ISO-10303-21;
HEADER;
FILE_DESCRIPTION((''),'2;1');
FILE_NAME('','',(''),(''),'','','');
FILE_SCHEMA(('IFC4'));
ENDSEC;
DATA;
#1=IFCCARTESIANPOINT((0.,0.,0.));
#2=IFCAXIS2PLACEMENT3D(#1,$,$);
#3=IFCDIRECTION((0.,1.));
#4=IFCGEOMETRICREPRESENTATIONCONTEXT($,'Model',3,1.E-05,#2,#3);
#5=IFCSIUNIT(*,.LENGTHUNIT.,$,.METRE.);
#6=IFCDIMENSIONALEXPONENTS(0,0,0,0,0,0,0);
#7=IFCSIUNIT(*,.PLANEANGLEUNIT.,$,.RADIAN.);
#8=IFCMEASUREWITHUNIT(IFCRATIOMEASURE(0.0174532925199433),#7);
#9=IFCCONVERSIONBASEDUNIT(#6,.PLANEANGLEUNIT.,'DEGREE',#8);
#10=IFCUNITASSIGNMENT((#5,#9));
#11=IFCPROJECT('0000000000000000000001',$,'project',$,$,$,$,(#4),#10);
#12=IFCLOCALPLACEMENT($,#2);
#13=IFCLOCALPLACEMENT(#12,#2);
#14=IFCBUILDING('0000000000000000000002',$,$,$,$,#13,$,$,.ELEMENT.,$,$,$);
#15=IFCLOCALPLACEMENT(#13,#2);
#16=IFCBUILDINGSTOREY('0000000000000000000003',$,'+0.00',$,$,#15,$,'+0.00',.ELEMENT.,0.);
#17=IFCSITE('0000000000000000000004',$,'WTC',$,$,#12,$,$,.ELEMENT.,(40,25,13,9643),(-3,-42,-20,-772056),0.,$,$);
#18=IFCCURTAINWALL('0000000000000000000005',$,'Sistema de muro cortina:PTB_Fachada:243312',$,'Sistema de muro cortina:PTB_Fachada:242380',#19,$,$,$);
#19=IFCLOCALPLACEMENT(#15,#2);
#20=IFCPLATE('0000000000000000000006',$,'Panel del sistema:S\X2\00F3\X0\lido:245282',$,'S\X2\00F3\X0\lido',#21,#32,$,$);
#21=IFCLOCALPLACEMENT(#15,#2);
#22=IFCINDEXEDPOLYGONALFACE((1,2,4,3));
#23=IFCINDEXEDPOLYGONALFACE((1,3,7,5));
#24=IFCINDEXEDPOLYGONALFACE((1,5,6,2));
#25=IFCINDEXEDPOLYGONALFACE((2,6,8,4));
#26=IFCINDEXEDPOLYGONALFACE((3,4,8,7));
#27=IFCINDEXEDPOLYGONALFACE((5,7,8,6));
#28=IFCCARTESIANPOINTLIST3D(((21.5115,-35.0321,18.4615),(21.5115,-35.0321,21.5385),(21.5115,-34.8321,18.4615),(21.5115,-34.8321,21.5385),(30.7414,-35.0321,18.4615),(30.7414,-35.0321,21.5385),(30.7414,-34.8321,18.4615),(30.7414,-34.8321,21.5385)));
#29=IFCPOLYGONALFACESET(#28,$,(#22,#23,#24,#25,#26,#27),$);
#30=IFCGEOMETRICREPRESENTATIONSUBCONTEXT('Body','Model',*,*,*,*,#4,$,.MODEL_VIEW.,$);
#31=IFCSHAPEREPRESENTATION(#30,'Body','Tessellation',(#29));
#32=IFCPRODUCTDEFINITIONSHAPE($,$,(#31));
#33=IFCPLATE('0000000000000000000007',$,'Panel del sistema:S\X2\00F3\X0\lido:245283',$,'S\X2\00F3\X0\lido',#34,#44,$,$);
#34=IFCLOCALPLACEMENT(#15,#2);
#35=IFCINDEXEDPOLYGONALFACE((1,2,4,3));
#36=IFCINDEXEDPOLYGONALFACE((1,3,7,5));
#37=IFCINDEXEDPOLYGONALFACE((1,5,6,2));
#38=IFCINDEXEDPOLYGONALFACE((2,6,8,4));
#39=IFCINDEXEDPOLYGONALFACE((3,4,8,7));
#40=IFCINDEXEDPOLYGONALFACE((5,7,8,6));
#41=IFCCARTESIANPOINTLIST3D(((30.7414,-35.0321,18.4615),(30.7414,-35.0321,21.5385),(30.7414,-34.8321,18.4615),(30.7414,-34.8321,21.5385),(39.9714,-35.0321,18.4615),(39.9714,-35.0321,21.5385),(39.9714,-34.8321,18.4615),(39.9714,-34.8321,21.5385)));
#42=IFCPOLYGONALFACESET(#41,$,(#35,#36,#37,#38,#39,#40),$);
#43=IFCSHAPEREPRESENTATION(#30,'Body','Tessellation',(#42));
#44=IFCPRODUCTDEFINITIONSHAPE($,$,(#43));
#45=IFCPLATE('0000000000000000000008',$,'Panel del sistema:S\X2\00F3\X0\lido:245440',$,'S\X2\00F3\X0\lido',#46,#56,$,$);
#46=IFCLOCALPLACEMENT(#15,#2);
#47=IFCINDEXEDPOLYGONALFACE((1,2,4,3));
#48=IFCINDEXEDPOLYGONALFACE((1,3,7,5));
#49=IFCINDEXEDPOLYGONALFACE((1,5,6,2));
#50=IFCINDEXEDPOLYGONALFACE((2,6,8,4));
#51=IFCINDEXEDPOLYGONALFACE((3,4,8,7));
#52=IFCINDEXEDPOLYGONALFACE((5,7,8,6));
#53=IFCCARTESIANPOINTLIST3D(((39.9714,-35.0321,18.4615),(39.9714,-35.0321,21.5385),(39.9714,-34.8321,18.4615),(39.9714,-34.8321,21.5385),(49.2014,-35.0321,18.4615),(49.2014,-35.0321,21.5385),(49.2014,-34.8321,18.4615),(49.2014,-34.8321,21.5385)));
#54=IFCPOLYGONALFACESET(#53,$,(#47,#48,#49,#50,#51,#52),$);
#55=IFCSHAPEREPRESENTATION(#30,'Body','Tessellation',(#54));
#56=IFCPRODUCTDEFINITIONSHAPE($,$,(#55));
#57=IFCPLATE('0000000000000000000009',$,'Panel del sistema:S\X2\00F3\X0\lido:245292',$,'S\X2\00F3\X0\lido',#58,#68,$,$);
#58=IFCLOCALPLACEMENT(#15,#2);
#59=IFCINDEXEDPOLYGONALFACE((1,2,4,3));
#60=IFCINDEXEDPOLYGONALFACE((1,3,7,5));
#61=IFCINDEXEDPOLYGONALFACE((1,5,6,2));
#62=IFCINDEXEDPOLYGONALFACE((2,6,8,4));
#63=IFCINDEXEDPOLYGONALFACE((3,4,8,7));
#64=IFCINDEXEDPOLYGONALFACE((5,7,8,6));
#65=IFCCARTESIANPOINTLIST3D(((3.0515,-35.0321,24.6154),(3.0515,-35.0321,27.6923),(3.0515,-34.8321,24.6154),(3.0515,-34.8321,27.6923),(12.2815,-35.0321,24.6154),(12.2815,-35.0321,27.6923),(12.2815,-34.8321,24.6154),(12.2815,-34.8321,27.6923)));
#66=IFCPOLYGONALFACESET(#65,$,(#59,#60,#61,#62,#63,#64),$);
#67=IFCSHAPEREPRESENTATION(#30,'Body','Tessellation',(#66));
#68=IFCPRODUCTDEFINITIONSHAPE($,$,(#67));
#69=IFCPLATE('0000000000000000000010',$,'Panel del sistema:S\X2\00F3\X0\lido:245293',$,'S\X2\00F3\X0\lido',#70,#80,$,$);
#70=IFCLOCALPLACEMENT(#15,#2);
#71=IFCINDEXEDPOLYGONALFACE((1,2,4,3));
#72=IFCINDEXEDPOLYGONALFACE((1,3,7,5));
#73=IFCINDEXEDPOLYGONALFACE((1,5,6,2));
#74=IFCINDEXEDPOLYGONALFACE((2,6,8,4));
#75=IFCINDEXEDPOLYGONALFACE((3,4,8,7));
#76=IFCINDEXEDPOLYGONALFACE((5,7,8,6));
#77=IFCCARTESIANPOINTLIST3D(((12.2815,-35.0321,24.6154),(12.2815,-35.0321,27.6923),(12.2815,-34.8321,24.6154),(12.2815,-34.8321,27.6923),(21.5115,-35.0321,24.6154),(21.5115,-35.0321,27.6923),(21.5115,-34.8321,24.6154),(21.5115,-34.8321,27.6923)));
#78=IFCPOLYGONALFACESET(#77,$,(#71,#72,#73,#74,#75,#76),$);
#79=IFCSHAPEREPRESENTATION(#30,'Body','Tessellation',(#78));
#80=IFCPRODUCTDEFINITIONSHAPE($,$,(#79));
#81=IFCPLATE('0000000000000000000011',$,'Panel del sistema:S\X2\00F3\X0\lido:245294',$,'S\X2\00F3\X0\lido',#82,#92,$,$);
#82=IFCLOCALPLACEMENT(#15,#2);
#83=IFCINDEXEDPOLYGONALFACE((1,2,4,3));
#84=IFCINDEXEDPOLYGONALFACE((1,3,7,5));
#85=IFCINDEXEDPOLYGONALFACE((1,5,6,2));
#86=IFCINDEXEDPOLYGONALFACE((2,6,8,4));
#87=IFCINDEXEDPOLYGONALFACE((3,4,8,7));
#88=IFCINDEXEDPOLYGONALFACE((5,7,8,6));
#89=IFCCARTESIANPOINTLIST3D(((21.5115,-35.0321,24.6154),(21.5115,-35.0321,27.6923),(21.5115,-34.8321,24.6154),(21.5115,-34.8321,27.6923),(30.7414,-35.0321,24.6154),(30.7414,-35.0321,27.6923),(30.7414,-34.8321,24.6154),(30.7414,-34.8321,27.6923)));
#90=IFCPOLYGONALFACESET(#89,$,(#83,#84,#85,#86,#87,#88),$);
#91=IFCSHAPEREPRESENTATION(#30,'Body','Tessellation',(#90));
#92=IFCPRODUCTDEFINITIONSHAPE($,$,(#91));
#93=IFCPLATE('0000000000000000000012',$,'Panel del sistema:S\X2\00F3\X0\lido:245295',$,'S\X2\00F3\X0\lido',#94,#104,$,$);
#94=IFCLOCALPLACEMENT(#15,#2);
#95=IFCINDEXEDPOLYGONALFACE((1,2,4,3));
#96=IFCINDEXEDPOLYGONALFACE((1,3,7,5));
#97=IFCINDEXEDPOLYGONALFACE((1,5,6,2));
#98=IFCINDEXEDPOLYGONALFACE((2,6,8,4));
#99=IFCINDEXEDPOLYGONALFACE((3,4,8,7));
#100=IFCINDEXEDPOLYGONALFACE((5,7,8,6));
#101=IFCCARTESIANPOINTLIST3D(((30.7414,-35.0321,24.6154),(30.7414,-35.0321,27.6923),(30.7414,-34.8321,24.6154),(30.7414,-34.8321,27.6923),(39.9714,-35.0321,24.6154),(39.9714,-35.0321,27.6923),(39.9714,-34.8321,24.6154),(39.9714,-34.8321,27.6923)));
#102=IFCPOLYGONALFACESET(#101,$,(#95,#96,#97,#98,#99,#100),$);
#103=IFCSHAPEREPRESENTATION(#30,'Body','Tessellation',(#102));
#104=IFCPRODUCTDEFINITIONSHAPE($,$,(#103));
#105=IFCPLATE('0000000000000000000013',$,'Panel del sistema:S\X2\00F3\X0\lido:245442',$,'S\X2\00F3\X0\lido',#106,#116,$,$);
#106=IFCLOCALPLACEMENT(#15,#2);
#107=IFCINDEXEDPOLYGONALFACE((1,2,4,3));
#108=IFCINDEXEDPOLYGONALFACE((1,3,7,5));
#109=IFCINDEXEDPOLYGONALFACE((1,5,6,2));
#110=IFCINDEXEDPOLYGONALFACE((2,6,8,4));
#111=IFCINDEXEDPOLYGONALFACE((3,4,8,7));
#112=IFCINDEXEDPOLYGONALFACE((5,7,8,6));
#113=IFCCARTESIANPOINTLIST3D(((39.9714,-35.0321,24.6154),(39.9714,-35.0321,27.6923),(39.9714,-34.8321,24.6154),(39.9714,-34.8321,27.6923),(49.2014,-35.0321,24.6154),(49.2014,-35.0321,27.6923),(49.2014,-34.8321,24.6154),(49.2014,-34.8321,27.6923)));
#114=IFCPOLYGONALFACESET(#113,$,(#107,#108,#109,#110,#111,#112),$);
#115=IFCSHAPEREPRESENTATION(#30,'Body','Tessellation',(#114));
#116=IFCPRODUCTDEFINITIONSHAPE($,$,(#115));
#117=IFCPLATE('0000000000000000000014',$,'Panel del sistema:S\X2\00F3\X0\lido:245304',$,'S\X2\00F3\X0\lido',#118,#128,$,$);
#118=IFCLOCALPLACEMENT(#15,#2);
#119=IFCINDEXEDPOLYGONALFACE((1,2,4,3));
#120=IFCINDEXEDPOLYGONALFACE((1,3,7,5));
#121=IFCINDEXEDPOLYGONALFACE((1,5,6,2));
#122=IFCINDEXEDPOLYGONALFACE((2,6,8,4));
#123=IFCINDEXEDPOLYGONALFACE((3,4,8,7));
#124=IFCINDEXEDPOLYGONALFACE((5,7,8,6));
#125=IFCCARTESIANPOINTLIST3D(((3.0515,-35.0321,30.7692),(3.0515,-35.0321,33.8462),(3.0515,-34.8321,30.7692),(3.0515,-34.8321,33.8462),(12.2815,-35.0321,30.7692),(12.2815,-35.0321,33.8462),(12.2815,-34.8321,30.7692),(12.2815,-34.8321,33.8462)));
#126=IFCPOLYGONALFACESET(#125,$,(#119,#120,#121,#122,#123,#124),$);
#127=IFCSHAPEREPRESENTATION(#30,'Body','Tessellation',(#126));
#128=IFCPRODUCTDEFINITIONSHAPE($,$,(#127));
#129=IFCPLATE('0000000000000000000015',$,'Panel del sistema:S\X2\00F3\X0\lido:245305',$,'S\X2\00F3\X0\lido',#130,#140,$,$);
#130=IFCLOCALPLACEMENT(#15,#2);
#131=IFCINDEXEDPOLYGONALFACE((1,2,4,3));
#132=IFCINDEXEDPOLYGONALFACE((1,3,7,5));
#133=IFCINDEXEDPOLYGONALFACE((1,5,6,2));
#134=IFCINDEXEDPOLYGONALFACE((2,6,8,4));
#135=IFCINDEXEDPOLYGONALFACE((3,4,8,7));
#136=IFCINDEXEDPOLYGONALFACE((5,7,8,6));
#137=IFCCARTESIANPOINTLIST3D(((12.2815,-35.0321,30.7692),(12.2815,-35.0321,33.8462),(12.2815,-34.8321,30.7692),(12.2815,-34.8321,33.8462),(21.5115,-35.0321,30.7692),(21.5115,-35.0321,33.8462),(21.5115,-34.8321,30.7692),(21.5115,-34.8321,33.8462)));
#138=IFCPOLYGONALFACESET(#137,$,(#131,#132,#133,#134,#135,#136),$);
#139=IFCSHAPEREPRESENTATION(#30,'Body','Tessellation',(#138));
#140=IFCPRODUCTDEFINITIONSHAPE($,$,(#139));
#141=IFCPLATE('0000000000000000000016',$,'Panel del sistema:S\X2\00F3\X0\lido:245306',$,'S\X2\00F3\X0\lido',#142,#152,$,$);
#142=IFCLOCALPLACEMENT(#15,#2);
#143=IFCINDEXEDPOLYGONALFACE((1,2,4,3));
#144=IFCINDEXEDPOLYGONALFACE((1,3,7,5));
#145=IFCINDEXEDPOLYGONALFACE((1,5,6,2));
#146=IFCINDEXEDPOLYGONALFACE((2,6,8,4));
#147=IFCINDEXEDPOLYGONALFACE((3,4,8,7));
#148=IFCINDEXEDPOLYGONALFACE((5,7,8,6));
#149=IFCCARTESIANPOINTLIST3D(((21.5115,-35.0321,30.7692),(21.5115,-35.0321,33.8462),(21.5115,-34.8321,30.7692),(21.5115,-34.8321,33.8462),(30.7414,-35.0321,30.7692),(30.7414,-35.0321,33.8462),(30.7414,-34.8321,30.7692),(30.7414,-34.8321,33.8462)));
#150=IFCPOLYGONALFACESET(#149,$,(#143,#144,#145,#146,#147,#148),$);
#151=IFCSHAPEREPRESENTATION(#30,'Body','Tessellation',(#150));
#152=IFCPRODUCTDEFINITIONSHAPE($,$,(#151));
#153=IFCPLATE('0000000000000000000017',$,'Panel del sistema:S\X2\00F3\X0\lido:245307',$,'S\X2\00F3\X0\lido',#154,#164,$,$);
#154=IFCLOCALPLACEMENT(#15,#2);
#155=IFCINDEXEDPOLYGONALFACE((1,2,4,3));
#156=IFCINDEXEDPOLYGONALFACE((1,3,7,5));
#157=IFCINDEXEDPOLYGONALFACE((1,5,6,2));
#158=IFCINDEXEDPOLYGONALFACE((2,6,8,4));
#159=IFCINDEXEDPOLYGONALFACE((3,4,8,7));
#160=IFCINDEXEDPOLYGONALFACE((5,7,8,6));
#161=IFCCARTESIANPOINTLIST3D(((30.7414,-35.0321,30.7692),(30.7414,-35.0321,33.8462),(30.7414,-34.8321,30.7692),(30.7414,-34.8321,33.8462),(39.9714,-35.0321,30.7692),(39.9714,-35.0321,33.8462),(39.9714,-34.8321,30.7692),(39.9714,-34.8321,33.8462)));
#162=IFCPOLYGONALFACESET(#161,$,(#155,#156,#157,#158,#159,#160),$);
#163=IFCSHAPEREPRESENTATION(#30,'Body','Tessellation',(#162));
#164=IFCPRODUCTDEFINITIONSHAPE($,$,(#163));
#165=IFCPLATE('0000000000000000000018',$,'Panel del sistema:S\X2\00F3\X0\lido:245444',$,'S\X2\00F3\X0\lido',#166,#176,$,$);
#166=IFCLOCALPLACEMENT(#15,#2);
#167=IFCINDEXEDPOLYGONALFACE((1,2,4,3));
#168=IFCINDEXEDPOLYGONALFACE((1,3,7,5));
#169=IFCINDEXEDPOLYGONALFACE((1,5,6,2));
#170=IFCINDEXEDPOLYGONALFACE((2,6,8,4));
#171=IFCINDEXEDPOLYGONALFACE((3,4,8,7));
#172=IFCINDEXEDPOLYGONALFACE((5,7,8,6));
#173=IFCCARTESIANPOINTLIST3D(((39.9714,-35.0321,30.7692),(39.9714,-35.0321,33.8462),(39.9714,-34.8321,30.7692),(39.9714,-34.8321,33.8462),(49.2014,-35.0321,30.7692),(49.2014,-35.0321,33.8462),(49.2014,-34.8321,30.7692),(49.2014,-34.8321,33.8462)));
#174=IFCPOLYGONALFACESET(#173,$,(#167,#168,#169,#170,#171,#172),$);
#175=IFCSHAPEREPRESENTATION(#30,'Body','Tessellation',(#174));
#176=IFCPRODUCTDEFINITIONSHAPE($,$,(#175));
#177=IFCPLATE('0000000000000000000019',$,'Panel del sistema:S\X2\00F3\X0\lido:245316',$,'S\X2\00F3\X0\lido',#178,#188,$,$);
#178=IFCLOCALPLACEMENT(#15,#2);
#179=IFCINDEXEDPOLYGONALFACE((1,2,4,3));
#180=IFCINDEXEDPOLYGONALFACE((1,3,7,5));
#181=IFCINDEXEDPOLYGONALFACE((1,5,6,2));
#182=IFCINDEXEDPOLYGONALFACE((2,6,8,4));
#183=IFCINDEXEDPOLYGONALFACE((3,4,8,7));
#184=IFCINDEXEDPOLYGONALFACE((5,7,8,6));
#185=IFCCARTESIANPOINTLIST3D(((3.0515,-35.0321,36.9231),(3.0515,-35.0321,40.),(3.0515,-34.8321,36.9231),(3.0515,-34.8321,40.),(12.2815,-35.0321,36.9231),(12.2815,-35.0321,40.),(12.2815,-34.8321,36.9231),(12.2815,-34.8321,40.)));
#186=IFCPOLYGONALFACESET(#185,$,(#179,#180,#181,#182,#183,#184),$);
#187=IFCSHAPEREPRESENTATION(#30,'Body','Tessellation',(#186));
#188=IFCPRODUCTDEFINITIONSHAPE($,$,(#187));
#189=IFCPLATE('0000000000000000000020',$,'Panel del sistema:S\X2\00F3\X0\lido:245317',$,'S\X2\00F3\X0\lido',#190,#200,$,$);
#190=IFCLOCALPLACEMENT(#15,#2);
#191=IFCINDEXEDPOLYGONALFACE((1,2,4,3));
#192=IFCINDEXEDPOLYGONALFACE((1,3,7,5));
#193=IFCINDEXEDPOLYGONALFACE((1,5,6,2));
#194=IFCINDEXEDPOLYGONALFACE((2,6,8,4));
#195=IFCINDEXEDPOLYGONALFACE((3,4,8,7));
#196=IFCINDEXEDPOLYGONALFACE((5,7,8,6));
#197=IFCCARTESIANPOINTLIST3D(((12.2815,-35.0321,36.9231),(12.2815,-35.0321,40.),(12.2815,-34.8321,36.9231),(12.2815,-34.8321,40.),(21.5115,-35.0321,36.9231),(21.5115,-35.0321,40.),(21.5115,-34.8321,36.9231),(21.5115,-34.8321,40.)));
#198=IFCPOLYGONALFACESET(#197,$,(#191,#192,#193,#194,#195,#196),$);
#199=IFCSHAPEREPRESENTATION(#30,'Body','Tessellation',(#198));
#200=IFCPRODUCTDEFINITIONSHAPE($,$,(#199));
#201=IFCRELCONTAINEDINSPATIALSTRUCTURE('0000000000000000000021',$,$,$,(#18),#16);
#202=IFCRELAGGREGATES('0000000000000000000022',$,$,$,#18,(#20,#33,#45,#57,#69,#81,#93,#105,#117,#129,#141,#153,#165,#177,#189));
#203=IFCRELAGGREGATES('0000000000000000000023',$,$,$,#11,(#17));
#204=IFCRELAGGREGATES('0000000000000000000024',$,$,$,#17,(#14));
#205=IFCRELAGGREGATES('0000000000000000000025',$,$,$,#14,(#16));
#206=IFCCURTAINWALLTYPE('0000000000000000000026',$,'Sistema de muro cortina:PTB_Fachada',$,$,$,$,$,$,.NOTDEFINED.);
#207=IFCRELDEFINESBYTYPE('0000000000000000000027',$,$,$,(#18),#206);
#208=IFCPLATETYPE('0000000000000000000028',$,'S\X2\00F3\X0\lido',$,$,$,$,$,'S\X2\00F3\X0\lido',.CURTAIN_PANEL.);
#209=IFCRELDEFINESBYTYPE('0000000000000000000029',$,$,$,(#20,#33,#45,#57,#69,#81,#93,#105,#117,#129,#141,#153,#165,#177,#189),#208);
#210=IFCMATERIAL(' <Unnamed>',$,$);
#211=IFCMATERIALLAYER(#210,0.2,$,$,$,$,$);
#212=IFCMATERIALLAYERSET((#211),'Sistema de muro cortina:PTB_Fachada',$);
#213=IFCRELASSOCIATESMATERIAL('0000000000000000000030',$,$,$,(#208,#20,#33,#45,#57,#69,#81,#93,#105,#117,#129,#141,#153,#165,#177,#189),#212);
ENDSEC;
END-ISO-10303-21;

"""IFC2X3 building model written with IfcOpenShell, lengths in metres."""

from ifc_helpers import new_model, entity, si_unit, converted_unit, direction, frame, frame_2d, origin, place, context, subcontext, project, spatial, rectangle, extrude, source, transform, mapped, material, layer, layer_set, layer_usage, type_object, type_shapes, element, aggregate, save


model = new_model("IFC2X3")

# Units and contexts
model_context = context("Model", 3, precision=1e-05, world=origin(), true_north=direction((0.0, 1.0)))
body_context = subcontext(model_context, "Body", "Model", "MODEL_VIEW")
ifc_project = project(units=[si_unit("LENGTHUNIT", "METRE"), converted_unit("PLANEANGLEUNIT", "DEGREE", entity("IfcRatioMeasure", 0.0174532925199433), si_unit("PLANEANGLEUNIT", "RADIAN"), dimensions=[0, 0, 0, 0, 0, 0, 0])], contexts=[model_context])

# Site, building, storey
site_placement = place(None, origin())
site = spatial("IfcSite", under=ifc_project, at=site_placement, Name="WTC", CompositionType="ELEMENT", RefLatitude=(40, 25, 13, 9643), RefLongitude=(-3, -42, -20, -772056), RefElevation=0.0)
building_placement = place(site_placement, origin())
building = spatial("IfcBuilding", under=site, at=building_placement, CompositionType="ELEMENT")
storey_placement = place(building_placement, origin())
storey = spatial("IfcBuildingStorey", under=building, at=storey_placement, Name="+0.00", LongName="+0.00", CompositionType="ELEMENT", Elevation=0.0)

# Curtain wall, plates
curtain_wall_type = type_object("IfcCurtainWallType", Name="Sistema de muro cortina:PTB_Fachada", PredefinedType="NOTDEFINED")
curtain_wall_placement = place(storey_placement, origin())
curtain_wall = element("IfcCurtainWall", 1, at=curtain_wall_placement, inside=storey, type_object=curtain_wall_type, Name="Sistema de muro cortina:PTB_Fachada:243312", ObjectType="Sistema de muro cortina:PTB_Fachada:242380")
ifc_material_1 = material(Name=" <Unnamed>")
ifc_layer_1 = layer(ifc_material_1, 0.2)
ifc_layer_set_1 = layer_set([ifc_layer_1], Name="Sistema de muro cortina:PTB_Fachada")
ifc_layer_usage_1 = layer_usage(ifc_layer_set_1, "AXIS3", "POSITIVE", 0.0)
plate_type_1 = type_object("IfcPlateType", Name="Sólido", ElementType="Sólido", PredefinedType="CURTAIN_PANEL", material=ifc_layer_set_1)
shared_shape_1 = source(origin(), body_context, "Body", "SweptSolid", [
    extrude(rectangle(XDim=0.2, YDim=9.23, at=frame_2d((0.0, 0.0), x_axis=(1.0, 0.0))), frame((0.0, 0.0, 0.0), z_axis=(0.0, 0.0, 1.0), x_axis=(0.0, 1.0, 0.0)), (0.0, 0.0, 1.0), 3.0769),
])
type_shapes(plate_type_1, [shared_shape_1])
plate_1_placement = place(curtain_wall_placement, frame((26.1265, -34.9321, 18.4615)))
plate_1 = element("IfcPlate", 2, at=plate_1_placement, type_object=plate_type_1, material=ifc_layer_usage_1, Name="Panel del sistema:Sólido:245282", ObjectType="Sólido", context=body_context, shape_type="MappedRepresentation", body=[
    mapped(shared_shape_1, transform((0.0, 0.0, 0.0), scale=1.0)),
])
ifc_layer_usage_2 = layer_usage(ifc_layer_set_1, "AXIS3", "POSITIVE", 0.0)
plate_2_placement = place(curtain_wall_placement, frame((35.3564, -34.9321, 18.4615)))
plate_2 = element("IfcPlate", 3, at=plate_2_placement, type_object=plate_type_1, material=ifc_layer_usage_2, Name="Panel del sistema:Sólido:245283", ObjectType="Sólido", context=body_context, shape_type="MappedRepresentation", body=[
    mapped(shared_shape_1, transform((0.0, 0.0, 0.0), scale=1.0)),
])
ifc_layer_usage_3 = layer_usage(ifc_layer_set_1, "AXIS3", "POSITIVE", 0.0)
plate_3_placement = place(curtain_wall_placement, frame((44.5864, -34.9321, 18.4615)))
plate_3 = element("IfcPlate", 4, at=plate_3_placement, type_object=plate_type_1, material=ifc_layer_usage_3, Name="Panel del sistema:Sólido:245440", ObjectType="Sólido", context=body_context, shape_type="MappedRepresentation", body=[
    mapped(shared_shape_1, transform((0.0, 0.0, 0.0), scale=1.0)),
])
ifc_layer_usage_4 = layer_usage(ifc_layer_set_1, "AXIS3", "POSITIVE", 0.0)
plate_4_placement = place(curtain_wall_placement, frame((7.6665, -34.9321, 24.6154)))
plate_4 = element("IfcPlate", 5, at=plate_4_placement, type_object=plate_type_1, material=ifc_layer_usage_4, Name="Panel del sistema:Sólido:245292", ObjectType="Sólido", context=body_context, shape_type="MappedRepresentation", body=[
    mapped(shared_shape_1, transform((0.0, 0.0, 0.0), scale=1.0)),
])
ifc_layer_usage_5 = layer_usage(ifc_layer_set_1, "AXIS3", "POSITIVE", 0.0)
plate_5_placement = place(curtain_wall_placement, frame((16.8965, -34.9321, 24.6154)))
plate_5 = element("IfcPlate", 6, at=plate_5_placement, type_object=plate_type_1, material=ifc_layer_usage_5, Name="Panel del sistema:Sólido:245293", ObjectType="Sólido", context=body_context, shape_type="MappedRepresentation", body=[
    mapped(shared_shape_1, transform((0.0, 0.0, 0.0), scale=1.0)),
])
ifc_layer_usage_6 = layer_usage(ifc_layer_set_1, "AXIS3", "POSITIVE", 0.0)
plate_6_placement = place(curtain_wall_placement, frame((26.1265, -34.9321, 24.6154)))
plate_6 = element("IfcPlate", 7, at=plate_6_placement, type_object=plate_type_1, material=ifc_layer_usage_6, Name="Panel del sistema:Sólido:245294", ObjectType="Sólido", context=body_context, shape_type="MappedRepresentation", body=[
    mapped(shared_shape_1, transform((0.0, 0.0, 0.0), scale=1.0)),
])
ifc_layer_usage_7 = layer_usage(ifc_layer_set_1, "AXIS3", "POSITIVE", 0.0)
plate_7_placement = place(curtain_wall_placement, frame((35.3564, -34.9321, 24.6154)))
plate_7 = element("IfcPlate", 8, at=plate_7_placement, type_object=plate_type_1, material=ifc_layer_usage_7, Name="Panel del sistema:Sólido:245295", ObjectType="Sólido", context=body_context, shape_type="MappedRepresentation", body=[
    mapped(shared_shape_1, transform((0.0, 0.0, 0.0), scale=1.0)),
])
ifc_layer_usage_8 = layer_usage(ifc_layer_set_1, "AXIS3", "POSITIVE", 0.0)
plate_8_placement = place(curtain_wall_placement, frame((44.5864, -34.9321, 24.6154)))
plate_8 = element("IfcPlate", 9, at=plate_8_placement, type_object=plate_type_1, material=ifc_layer_usage_8, Name="Panel del sistema:Sólido:245442", ObjectType="Sólido", context=body_context, shape_type="MappedRepresentation", body=[
    mapped(shared_shape_1, transform((0.0, 0.0, 0.0), scale=1.0)),
])
ifc_layer_usage_9 = layer_usage(ifc_layer_set_1, "AXIS3", "POSITIVE", 0.0)
plate_9_placement = place(curtain_wall_placement, frame((7.6665, -34.9321, 30.7692)))
plate_9 = element("IfcPlate", 10, at=plate_9_placement, type_object=plate_type_1, material=ifc_layer_usage_9, Name="Panel del sistema:Sólido:245304", ObjectType="Sólido", context=body_context, shape_type="MappedRepresentation", body=[
    mapped(shared_shape_1, transform((0.0, 0.0, 0.0), scale=1.0)),
])
ifc_layer_usage_10 = layer_usage(ifc_layer_set_1, "AXIS3", "POSITIVE", 0.0)
plate_10_placement = place(curtain_wall_placement, frame((16.8965, -34.9321, 30.7692)))
plate_10 = element("IfcPlate", 11, at=plate_10_placement, type_object=plate_type_1, material=ifc_layer_usage_10, Name="Panel del sistema:Sólido:245305", ObjectType="Sólido", context=body_context, shape_type="MappedRepresentation", body=[
    mapped(shared_shape_1, transform((0.0, 0.0, 0.0), scale=1.0)),
])
ifc_layer_usage_11 = layer_usage(ifc_layer_set_1, "AXIS3", "POSITIVE", 0.0)
plate_11_placement = place(curtain_wall_placement, frame((26.1265, -34.9321, 30.7692)))
plate_11 = element("IfcPlate", 12, at=plate_11_placement, type_object=plate_type_1, material=ifc_layer_usage_11, Name="Panel del sistema:Sólido:245306", ObjectType="Sólido", context=body_context, shape_type="MappedRepresentation", body=[
    mapped(shared_shape_1, transform((0.0, 0.0, 0.0), scale=1.0)),
])
ifc_layer_usage_12 = layer_usage(ifc_layer_set_1, "AXIS3", "POSITIVE", 0.0)
plate_12_placement = place(curtain_wall_placement, frame((35.3564, -34.9321, 30.7692)))
plate_12 = element("IfcPlate", 13, at=plate_12_placement, type_object=plate_type_1, material=ifc_layer_usage_12, Name="Panel del sistema:Sólido:245307", ObjectType="Sólido", context=body_context, shape_type="MappedRepresentation", body=[
    mapped(shared_shape_1, transform((0.0, 0.0, 0.0), scale=1.0)),
])
ifc_layer_usage_13 = layer_usage(ifc_layer_set_1, "AXIS3", "POSITIVE", 0.0)
plate_13_placement = place(curtain_wall_placement, frame((44.5864, -34.9321, 30.7692)))
plate_13 = element("IfcPlate", 14, at=plate_13_placement, type_object=plate_type_1, material=ifc_layer_usage_13, Name="Panel del sistema:Sólido:245444", ObjectType="Sólido", context=body_context, shape_type="MappedRepresentation", body=[
    mapped(shared_shape_1, transform((0.0, 0.0, 0.0), scale=1.0)),
])
ifc_layer_usage_14 = layer_usage(ifc_layer_set_1, "AXIS3", "POSITIVE", 0.0)
plate_14_placement = place(curtain_wall_placement, frame((7.6665, -34.9321, 36.9231)))
plate_14 = element("IfcPlate", 15, at=plate_14_placement, type_object=plate_type_1, material=ifc_layer_usage_14, Name="Panel del sistema:Sólido:245316", ObjectType="Sólido", context=body_context, shape_type="MappedRepresentation", body=[
    mapped(shared_shape_1, transform((0.0, 0.0, 0.0), scale=1.0)),
])
ifc_layer_usage_15 = layer_usage(ifc_layer_set_1, "AXIS3", "POSITIVE", 0.0)
plate_15_placement = place(curtain_wall_placement, frame((16.8965, -34.9321, 36.9231)))
plate_15 = element("IfcPlate", 16, at=plate_15_placement, type_object=plate_type_1, material=ifc_layer_usage_15, Name="Panel del sistema:Sólido:245317", ObjectType="Sólido", context=body_context, shape_type="MappedRepresentation", body=[
    mapped(shared_shape_1, transform((0.0, 0.0, 0.0), scale=1.0)),
])
aggregate(curtain_wall, [plate_1, plate_2, plate_3, plate_4, plate_5, plate_6, plate_7, plate_8, plate_9, plate_10, plate_11, plate_12, plate_13, plate_14, plate_15])

save(model, "model.ifc")
